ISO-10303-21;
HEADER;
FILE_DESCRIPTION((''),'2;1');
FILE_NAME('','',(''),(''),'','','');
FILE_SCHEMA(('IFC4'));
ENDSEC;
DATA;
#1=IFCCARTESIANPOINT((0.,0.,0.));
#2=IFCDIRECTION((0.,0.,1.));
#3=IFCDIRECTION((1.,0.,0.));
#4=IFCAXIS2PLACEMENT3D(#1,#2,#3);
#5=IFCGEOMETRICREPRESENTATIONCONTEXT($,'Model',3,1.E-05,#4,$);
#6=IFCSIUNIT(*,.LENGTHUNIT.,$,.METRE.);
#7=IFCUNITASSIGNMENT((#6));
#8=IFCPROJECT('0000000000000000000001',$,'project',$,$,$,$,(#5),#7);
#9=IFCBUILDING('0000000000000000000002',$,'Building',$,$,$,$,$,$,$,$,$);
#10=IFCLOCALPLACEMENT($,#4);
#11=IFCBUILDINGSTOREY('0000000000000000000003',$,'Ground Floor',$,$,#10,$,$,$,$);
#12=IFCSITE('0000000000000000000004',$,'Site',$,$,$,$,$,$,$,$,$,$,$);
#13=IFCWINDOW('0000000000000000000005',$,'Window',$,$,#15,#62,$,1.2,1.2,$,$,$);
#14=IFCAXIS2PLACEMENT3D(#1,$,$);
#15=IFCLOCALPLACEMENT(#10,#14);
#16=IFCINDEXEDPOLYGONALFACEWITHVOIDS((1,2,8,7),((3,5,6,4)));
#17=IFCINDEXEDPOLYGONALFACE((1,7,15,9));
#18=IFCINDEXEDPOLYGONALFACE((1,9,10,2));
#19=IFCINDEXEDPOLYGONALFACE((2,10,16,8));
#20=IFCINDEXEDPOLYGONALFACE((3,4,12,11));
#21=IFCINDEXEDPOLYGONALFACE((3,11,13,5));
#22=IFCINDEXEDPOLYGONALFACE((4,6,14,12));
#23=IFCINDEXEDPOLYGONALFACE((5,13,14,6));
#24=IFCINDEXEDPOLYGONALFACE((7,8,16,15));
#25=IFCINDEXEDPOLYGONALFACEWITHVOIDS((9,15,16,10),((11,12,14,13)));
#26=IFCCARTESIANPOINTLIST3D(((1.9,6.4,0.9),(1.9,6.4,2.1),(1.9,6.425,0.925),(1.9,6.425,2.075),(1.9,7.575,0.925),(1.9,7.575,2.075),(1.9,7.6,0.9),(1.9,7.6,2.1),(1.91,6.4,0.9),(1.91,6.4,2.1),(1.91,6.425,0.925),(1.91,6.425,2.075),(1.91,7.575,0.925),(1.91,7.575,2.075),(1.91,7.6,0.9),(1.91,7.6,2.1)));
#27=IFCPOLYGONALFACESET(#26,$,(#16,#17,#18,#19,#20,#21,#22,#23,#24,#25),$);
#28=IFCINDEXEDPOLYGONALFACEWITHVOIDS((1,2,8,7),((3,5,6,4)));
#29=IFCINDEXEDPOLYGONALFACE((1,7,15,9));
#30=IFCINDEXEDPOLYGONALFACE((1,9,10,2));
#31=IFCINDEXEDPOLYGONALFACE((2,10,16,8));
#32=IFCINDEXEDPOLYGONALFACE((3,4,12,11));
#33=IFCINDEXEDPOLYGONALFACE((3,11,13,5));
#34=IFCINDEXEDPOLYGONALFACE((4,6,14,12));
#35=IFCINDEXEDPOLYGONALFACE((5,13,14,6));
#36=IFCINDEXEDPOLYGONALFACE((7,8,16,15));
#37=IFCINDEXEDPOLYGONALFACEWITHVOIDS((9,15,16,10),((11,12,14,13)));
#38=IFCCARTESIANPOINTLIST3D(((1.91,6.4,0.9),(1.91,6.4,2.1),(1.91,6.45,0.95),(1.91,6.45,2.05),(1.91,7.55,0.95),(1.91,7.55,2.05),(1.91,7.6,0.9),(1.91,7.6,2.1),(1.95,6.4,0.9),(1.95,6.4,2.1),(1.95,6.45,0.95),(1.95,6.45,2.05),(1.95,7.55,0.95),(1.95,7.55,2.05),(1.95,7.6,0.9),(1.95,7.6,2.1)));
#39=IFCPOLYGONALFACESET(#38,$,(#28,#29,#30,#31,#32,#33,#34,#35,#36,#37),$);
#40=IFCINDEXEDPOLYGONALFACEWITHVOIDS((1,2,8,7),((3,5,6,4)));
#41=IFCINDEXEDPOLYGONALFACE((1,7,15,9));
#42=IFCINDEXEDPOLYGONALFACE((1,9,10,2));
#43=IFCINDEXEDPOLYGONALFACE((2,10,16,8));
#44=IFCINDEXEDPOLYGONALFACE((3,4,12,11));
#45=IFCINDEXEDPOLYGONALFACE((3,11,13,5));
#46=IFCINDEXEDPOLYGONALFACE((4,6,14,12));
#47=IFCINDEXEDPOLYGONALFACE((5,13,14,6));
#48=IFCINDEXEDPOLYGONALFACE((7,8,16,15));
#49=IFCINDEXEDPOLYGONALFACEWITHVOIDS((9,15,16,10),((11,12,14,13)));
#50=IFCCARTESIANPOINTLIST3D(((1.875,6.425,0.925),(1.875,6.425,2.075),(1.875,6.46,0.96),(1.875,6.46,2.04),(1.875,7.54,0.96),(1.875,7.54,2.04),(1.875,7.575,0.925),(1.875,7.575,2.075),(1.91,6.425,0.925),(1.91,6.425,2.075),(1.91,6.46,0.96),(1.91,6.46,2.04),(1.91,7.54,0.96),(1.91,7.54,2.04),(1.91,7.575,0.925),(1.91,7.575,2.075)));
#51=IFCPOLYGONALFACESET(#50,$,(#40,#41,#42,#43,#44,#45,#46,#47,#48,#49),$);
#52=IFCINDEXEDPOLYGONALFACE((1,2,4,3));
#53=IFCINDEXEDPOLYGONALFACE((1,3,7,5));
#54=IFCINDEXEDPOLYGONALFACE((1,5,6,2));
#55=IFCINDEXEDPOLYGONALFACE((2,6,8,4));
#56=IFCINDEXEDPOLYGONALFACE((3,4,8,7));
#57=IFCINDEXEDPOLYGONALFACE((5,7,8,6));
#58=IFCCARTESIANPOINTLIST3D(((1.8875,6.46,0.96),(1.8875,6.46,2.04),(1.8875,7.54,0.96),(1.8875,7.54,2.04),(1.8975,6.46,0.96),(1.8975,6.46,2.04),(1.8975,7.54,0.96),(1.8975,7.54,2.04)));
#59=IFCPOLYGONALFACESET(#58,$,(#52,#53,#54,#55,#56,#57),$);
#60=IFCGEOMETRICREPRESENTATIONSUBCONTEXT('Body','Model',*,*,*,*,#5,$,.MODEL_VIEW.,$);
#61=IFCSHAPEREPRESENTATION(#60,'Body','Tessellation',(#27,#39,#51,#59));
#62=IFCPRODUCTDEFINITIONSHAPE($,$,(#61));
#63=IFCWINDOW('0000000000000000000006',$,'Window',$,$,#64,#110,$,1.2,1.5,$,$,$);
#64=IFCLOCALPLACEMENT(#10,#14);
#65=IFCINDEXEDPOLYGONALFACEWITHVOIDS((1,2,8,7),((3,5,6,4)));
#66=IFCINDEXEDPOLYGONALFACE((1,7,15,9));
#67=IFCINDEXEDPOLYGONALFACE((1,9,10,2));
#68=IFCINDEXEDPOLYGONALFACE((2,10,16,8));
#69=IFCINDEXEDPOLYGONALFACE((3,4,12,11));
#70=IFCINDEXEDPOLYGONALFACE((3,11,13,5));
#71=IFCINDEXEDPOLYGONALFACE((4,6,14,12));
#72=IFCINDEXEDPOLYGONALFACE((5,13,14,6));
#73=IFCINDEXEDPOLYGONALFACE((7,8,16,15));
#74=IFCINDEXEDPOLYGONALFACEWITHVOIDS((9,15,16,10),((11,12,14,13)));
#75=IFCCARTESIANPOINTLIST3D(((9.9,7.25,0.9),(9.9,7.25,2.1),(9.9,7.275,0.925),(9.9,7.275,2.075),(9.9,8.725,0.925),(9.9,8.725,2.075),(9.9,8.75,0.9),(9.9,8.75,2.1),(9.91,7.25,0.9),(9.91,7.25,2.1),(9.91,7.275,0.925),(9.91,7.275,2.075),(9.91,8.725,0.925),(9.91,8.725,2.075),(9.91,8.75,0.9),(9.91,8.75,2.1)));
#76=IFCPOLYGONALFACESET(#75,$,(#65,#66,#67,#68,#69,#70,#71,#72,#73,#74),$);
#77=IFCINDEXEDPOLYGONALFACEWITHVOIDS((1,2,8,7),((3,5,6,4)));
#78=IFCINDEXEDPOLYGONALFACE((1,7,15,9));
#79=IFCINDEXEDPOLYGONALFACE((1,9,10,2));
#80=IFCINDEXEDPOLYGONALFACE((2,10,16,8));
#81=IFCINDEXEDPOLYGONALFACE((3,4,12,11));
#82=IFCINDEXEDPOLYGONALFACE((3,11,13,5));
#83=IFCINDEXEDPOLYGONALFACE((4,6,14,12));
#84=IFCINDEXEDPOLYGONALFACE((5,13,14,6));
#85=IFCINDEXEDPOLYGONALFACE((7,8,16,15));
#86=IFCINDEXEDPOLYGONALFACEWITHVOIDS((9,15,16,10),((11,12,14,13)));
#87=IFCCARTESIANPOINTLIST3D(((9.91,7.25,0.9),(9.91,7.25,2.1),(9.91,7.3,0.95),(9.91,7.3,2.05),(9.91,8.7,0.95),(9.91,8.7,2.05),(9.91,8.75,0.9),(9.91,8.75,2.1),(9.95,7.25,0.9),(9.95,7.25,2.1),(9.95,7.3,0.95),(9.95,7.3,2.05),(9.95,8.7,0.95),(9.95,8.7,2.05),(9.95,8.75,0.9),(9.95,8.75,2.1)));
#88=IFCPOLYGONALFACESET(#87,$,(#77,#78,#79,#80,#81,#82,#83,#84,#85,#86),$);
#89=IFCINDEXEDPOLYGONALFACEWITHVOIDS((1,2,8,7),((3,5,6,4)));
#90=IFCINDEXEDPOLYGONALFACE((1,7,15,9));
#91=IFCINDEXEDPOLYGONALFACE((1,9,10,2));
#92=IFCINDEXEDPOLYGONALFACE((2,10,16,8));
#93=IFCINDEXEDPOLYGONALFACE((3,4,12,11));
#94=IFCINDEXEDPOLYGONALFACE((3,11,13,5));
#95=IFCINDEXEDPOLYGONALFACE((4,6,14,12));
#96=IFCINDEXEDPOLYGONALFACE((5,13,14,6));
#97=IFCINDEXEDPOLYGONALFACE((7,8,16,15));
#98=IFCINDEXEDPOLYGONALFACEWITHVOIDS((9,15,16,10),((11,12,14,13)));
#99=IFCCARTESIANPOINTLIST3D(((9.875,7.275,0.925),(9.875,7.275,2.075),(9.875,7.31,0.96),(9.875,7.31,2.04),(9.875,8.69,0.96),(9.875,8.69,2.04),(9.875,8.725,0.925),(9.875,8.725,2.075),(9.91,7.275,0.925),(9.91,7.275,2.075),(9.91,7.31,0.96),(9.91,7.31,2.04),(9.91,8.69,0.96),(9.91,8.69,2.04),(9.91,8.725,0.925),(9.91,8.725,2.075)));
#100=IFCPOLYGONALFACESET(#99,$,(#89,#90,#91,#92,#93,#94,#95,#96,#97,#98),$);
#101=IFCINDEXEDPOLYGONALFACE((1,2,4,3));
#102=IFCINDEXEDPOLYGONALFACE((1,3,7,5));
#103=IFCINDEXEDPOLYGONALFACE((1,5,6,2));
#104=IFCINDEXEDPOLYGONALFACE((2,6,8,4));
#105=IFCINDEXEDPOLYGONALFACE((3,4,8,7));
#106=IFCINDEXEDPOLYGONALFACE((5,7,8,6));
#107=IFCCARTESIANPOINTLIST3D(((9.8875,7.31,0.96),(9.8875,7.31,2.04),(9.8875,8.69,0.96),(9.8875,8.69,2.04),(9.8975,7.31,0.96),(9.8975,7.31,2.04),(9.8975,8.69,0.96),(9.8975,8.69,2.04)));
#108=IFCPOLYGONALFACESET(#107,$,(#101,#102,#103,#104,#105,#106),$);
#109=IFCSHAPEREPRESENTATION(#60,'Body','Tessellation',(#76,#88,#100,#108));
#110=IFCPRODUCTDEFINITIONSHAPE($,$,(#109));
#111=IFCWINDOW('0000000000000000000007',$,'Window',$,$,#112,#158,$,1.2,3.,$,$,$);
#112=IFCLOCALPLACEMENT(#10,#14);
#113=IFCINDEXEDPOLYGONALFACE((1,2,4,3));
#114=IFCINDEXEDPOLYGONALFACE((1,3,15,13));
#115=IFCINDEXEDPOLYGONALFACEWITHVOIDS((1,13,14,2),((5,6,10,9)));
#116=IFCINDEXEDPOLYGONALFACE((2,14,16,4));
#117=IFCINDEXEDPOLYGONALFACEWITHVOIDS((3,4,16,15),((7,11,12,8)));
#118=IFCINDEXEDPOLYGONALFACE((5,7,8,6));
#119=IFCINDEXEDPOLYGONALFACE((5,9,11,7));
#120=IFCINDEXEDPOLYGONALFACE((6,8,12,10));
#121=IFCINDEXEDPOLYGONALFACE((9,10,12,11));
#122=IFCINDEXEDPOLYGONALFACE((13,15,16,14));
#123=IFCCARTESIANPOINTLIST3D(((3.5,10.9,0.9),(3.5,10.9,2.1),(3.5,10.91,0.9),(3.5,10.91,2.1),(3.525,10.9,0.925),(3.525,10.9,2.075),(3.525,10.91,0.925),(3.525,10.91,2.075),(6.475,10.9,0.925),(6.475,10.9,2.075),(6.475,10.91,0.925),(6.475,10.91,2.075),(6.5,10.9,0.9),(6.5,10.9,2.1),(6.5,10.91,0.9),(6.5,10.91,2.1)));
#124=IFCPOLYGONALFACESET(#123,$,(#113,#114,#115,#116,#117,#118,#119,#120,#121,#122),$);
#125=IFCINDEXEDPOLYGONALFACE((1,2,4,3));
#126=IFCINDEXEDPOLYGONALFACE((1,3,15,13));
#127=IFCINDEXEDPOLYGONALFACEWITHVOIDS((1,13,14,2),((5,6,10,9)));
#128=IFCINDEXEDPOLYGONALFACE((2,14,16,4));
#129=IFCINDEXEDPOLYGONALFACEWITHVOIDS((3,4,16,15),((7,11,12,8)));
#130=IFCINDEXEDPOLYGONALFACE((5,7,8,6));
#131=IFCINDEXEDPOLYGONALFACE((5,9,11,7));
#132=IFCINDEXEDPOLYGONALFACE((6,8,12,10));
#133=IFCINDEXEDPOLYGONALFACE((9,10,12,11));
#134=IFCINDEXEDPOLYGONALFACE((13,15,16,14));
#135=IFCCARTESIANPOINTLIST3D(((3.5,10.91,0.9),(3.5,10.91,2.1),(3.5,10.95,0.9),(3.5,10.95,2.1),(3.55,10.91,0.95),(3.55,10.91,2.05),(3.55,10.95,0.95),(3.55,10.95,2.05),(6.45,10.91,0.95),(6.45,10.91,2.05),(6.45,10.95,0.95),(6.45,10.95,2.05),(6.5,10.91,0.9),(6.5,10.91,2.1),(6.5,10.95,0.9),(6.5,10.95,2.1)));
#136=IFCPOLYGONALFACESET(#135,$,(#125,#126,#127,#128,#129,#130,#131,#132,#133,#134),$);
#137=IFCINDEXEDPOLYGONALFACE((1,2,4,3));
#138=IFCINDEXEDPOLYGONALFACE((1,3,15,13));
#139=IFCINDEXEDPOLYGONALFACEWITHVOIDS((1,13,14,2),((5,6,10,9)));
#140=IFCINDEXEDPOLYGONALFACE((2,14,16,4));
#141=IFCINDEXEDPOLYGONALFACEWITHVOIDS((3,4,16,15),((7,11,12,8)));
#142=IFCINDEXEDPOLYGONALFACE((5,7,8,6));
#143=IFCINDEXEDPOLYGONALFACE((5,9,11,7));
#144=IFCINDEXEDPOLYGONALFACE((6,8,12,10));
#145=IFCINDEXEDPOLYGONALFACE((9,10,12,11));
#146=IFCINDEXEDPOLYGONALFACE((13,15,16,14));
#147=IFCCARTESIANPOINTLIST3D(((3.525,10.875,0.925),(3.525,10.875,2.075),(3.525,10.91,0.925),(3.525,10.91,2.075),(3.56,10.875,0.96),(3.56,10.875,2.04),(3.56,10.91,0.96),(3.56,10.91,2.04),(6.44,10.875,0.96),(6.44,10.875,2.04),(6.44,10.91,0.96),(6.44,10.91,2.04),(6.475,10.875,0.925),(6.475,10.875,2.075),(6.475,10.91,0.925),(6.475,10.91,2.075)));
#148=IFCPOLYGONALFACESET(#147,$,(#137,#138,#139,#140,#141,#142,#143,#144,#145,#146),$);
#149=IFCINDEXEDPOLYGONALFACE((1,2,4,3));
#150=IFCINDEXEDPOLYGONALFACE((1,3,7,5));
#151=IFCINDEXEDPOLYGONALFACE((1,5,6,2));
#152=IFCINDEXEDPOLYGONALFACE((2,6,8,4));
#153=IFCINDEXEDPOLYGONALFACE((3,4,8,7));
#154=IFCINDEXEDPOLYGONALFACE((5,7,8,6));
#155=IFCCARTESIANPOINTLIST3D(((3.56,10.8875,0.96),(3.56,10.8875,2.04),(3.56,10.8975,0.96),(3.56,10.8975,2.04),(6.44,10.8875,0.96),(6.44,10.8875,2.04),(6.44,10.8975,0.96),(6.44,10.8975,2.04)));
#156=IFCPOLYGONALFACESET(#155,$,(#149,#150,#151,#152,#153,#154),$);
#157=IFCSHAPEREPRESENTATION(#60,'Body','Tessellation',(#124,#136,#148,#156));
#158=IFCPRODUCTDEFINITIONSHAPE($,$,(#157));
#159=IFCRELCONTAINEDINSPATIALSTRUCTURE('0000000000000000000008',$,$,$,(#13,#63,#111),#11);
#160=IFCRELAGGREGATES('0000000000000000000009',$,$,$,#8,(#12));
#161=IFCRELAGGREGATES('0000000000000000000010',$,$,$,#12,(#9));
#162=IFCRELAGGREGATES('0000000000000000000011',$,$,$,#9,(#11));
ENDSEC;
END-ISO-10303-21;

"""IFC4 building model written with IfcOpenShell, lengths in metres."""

from ifc_helpers import new_model, si_unit, frame, origin_with_axes, place, context, subcontext, project, spatial, line, indexed_curve, outline, extrude, element, save


model = new_model("IFC4")

# Units and contexts
model_context = context("Model", 3, precision=1e-05, world=origin_with_axes())
body_context = subcontext(model_context, "Body", "Model", "MODEL_VIEW")
ifc_project = project(units=[si_unit("LENGTHUNIT", "METRE")], contexts=[model_context])

# Site, building, storey
site = spatial("IfcSite", under=ifc_project, Name="Site")
building = spatial("IfcBuilding", under=site, Name="Building")
storey_placement = place(None, origin_with_axes())
storey = spatial("IfcBuildingStorey", under=building, at=storey_placement, Name="Ground Floor")

# Windows
window_1_placement = place(storey_placement, frame((2.0, 6.4, 0.9), z_axis=(0.0, 0.0, 1.0), x_axis=(0.0, 1.0, 0.0)))
element("IfcWindow", 1, at=window_1_placement, inside=storey, Name="Window", OverallHeight=1.2, OverallWidth=1.2, context=body_context, shape_type="SweptSolid", body=[
    extrude(outline(indexed_curve([(0.0, 0.0), (1.2, 0.0), (1.2, 1.2), (0.0, 1.2)], segments=[line(1, 2, 3, 4, 1)]), holes=[indexed_curve([(0.025, 0.025), (1.175, 0.025), (1.175, 1.175), (0.025, 1.175)], segments=[line(1, 2, 3, 4, 1)])]), frame((0.0, 0.09, 0.0), z_axis=(0.0, -1.0, 0.0), x_axis=(1.0, 0.0, 0.0)), (0.0, 0.0, -1.0), 0.01),
    extrude(outline(indexed_curve([(0.0, 0.0), (1.2, 0.0), (1.2, 1.2), (0.0, 1.2)], segments=[line(1, 2, 3, 4, 1)]), holes=[indexed_curve([(0.05, 0.05), (1.15, 0.05), (1.15, 1.15), (0.05, 1.15)], segments=[line(1, 2, 3, 4, 1)])]), frame((0.0, 0.05, 0.0), z_axis=(0.0, -1.0, 0.0), x_axis=(1.0, 0.0, 0.0)), (0.0, 0.0, -1.0), 0.04),
    extrude(outline(indexed_curve([(0.0, 0.0), (1.15, 0.0), (1.15, 1.15), (0.0, 1.15)], segments=[line(1, 2, 3, 4, 1)]), holes=[indexed_curve([(0.035, 0.035), (1.115, 0.035), (1.115, 1.115), (0.035, 1.115)], segments=[line(1, 2, 3, 4, 1)])]), frame((0.025, 0.09, 0.025), z_axis=(0.0, -1.0, 0.0), x_axis=(1.0, 0.0, 0.0)), (0.0, 0.0, -1.0), 0.035),
    extrude(outline(indexed_curve([(0.035, 0.035), (1.115, 0.035), (1.115, 1.115), (0.035, 1.115)], segments=[line(1, 2, 3, 4, 1)])), frame((0.025, 0.1025, 0.025), z_axis=(0.0, -1.0, 0.0), x_axis=(1.0, 0.0, 0.0)), (0.0, 0.0, -1.0), 0.01),
])
window_2_placement = place(storey_placement, frame((10.0, 7.25, 0.9), z_axis=(0.0, 0.0, 1.0), x_axis=(0.0, 1.0, 0.0)))
element("IfcWindow", 2, at=window_2_placement, inside=storey, Name="Window", OverallHeight=1.2, OverallWidth=1.5, context=body_context, shape_type="SweptSolid", body=[
    extrude(outline(indexed_curve([(0.0, 0.0), (1.5, 0.0), (1.5, 1.2), (0.0, 1.2)], segments=[line(1, 2, 3, 4, 1)]), holes=[indexed_curve([(0.025, 0.025), (1.475, 0.025), (1.475, 1.175), (0.025, 1.175)], segments=[line(1, 2, 3, 4, 1)])]), frame((0.0, 0.09, 0.0), z_axis=(0.0, -1.0, 0.0), x_axis=(1.0, 0.0, 0.0)), (0.0, 0.0, -1.0), 0.01),
    extrude(outline(indexed_curve([(0.0, 0.0), (1.5, 0.0), (1.5, 1.2), (0.0, 1.2)], segments=[line(1, 2, 3, 4, 1)]), holes=[indexed_curve([(0.05, 0.05), (1.45, 0.05), (1.45, 1.15), (0.05, 1.15)], segments=[line(1, 2, 3, 4, 1)])]), frame((0.0, 0.05, 0.0), z_axis=(0.0, -1.0, 0.0), x_axis=(1.0, 0.0, 0.0)), (0.0, 0.0, -1.0), 0.04),
    extrude(outline(indexed_curve([(0.0, 0.0), (1.45, 0.0), (1.45, 1.15), (0.0, 1.15)], segments=[line(1, 2, 3, 4, 1)]), holes=[indexed_curve([(0.035, 0.035), (1.415, 0.035), (1.415, 1.115), (0.035, 1.115)], segments=[line(1, 2, 3, 4, 1)])]), frame((0.025, 0.09, 0.025), z_axis=(0.0, -1.0, 0.0), x_axis=(1.0, 0.0, 0.0)), (0.0, 0.0, -1.0), 0.035),
    extrude(outline(indexed_curve([(0.035, 0.035), (1.415, 0.035), (1.415, 1.115), (0.035, 1.115)], segments=[line(1, 2, 3, 4, 1)])), frame((0.025, 0.1025, 0.025), z_axis=(0.0, -1.0, 0.0), x_axis=(1.0, 0.0, 0.0)), (0.0, 0.0, -1.0), 0.01),
])
window_3_placement = place(storey_placement, frame((6.5, 11.0, 0.9), z_axis=(0.0, 0.0, 1.0), x_axis=(-1.0, 0.0, 0.0)))
element("IfcWindow", 3, at=window_3_placement, inside=storey, Name="Window", OverallHeight=1.2, OverallWidth=3.0, context=body_context, shape_type="SweptSolid", body=[
    extrude(outline(indexed_curve([(0.0, 0.0), (3.0, 0.0), (3.0, 1.2), (0.0, 1.2)], segments=[line(1, 2, 3, 4, 1)]), holes=[indexed_curve([(0.025, 0.025), (2.975, 0.025), (2.975, 1.175), (0.025, 1.175)], segments=[line(1, 2, 3, 4, 1)])]), frame((0.0, 0.09, 0.0), z_axis=(0.0, -1.0, 0.0), x_axis=(1.0, 0.0, 0.0)), (0.0, 0.0, -1.0), 0.01),
    extrude(outline(indexed_curve([(0.0, 0.0), (3.0, 0.0), (3.0, 1.2), (0.0, 1.2)], segments=[line(1, 2, 3, 4, 1)]), holes=[indexed_curve([(0.05, 0.05), (2.95, 0.05), (2.95, 1.15), (0.05, 1.15)], segments=[line(1, 2, 3, 4, 1)])]), frame((0.0, 0.05, 0.0), z_axis=(0.0, -1.0, 0.0), x_axis=(1.0, 0.0, 0.0)), (0.0, 0.0, -1.0), 0.04),
    extrude(outline(indexed_curve([(0.0, 0.0), (2.95, 0.0), (2.95, 1.15), (0.0, 1.15)], segments=[line(1, 2, 3, 4, 1)]), holes=[indexed_curve([(0.035, 0.035), (2.915, 0.035), (2.915, 1.115), (0.035, 1.115)], segments=[line(1, 2, 3, 4, 1)])]), frame((0.025, 0.09, 0.025), z_axis=(0.0, -1.0, 0.0), x_axis=(1.0, 0.0, 0.0)), (0.0, 0.0, -1.0), 0.035),
    extrude(outline(indexed_curve([(0.035, 0.035), (2.915, 0.035), (2.915, 1.115), (0.035, 1.115)], segments=[line(1, 2, 3, 4, 1)])), frame((0.025, 0.1025, 0.025), z_axis=(0.0, -1.0, 0.0), x_axis=(1.0, 0.0, 0.0)), (0.0, 0.0, -1.0), 0.01),
])

save(model, "model.ifc")
